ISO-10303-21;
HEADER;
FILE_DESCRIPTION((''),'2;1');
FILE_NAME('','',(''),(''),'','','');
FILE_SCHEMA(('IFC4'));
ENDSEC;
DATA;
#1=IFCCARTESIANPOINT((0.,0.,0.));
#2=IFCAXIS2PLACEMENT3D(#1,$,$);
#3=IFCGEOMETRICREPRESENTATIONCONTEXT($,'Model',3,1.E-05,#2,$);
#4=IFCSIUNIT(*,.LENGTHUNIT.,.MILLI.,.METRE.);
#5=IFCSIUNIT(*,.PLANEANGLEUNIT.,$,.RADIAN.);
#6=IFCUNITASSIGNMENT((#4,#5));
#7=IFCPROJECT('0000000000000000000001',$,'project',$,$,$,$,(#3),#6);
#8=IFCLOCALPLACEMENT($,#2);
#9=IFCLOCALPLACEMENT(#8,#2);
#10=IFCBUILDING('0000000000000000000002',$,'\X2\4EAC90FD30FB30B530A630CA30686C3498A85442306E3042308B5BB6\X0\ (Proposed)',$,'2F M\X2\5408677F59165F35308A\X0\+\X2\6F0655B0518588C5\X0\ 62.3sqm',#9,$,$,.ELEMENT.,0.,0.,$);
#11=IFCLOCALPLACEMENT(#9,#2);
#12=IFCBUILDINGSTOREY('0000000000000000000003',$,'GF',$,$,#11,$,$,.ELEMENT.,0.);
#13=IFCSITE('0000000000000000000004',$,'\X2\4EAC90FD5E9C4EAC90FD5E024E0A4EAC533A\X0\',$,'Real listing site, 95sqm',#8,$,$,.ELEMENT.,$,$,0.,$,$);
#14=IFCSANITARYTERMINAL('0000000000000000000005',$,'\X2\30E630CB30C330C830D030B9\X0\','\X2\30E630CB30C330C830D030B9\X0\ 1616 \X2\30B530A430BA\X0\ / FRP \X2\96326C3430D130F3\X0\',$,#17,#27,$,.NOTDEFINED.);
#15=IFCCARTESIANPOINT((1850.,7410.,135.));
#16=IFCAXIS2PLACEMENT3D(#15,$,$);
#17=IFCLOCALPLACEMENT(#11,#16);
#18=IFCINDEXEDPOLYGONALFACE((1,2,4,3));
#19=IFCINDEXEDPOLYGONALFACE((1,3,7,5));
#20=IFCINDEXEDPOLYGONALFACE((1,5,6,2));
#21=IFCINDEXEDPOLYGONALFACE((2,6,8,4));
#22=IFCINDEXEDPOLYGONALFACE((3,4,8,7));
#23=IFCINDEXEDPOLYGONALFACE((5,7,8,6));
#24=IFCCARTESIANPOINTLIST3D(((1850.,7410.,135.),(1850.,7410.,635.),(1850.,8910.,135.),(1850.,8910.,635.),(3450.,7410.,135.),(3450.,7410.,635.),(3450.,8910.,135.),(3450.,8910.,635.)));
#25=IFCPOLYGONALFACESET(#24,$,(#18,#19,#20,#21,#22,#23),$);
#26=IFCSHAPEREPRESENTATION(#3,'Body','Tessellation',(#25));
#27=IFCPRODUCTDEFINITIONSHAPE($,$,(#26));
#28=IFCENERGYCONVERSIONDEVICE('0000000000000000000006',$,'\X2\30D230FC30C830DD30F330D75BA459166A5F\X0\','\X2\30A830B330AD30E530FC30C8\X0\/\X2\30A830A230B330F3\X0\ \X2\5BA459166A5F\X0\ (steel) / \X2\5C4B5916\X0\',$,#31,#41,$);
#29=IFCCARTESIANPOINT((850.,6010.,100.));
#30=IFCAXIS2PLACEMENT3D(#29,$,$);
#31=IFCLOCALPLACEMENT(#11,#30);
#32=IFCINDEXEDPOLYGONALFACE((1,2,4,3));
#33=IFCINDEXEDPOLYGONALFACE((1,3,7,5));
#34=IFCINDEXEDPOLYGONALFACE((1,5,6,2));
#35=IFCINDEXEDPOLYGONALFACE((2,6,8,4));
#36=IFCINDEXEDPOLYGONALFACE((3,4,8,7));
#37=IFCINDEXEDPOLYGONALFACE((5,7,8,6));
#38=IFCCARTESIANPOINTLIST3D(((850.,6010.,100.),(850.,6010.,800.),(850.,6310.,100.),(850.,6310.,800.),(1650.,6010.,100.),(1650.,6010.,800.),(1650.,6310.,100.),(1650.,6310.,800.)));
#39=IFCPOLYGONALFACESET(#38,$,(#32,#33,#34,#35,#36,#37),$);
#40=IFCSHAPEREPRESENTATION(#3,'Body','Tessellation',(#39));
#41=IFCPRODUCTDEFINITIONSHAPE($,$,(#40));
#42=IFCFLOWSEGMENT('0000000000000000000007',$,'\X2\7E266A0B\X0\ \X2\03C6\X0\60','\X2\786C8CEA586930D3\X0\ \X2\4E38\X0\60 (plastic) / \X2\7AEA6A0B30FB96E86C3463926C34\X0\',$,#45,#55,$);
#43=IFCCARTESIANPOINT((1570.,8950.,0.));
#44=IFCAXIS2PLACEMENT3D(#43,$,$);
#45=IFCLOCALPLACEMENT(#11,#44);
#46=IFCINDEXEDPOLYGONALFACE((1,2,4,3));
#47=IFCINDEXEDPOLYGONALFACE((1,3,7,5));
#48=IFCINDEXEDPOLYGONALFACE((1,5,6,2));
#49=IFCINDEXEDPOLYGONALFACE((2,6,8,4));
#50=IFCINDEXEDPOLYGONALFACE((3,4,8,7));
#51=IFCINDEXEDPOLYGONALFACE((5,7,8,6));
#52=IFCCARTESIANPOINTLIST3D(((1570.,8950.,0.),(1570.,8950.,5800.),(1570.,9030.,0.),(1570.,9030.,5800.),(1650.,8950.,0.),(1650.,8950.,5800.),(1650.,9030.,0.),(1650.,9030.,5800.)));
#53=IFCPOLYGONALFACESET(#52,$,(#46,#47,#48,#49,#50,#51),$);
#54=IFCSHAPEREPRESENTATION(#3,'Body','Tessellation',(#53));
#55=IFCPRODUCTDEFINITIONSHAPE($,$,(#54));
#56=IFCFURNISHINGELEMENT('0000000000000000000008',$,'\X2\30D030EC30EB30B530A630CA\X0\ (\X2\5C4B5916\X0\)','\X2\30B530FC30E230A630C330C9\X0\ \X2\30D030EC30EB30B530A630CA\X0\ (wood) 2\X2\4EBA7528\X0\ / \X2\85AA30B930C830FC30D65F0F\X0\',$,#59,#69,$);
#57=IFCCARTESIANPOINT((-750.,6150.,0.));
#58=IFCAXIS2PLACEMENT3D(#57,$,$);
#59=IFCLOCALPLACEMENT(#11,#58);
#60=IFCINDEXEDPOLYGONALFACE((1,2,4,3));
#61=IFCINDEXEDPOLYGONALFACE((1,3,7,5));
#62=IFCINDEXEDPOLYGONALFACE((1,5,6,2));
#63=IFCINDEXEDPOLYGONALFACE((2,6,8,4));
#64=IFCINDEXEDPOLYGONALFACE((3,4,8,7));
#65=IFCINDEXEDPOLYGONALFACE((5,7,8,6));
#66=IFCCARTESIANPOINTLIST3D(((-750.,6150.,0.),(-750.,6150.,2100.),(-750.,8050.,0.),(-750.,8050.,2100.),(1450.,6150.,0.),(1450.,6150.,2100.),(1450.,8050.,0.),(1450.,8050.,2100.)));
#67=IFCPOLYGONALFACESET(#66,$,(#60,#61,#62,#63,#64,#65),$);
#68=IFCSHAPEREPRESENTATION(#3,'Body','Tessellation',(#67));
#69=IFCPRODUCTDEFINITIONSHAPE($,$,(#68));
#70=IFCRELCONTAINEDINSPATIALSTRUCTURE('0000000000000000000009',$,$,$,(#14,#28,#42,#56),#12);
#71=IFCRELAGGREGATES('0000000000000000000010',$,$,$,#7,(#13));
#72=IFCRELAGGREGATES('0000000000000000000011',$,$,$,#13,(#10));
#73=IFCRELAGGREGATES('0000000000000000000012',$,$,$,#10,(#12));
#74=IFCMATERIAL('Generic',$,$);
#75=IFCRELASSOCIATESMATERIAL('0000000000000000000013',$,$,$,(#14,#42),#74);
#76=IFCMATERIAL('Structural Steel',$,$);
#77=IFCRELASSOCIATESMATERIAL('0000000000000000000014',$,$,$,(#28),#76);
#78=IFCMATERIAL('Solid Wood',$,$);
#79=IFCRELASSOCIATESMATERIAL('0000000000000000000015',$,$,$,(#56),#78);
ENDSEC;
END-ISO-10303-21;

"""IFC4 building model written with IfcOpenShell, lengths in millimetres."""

from ifc_helpers import new_model, si_unit, frame, frame_2d, origin, place, context, project, spatial, rectangle, extrude, material, element, save


model = new_model("IFC4")

# Units and contexts
model_context = context("Model", 3, precision=1e-05, world=origin())
ifc_project = project(units=[si_unit("LENGTHUNIT", "METRE", prefix="MILLI"), si_unit("PLANEANGLEUNIT", "RADIAN")], contexts=[model_context])

# Site, building, storey
site_placement = place(None, origin())
site = spatial("IfcSite", under=ifc_project, at=site_placement, Name="京都府京都市上京区", ObjectType="Real listing site, 95sqm", CompositionType="ELEMENT", RefElevation=0.0)
building_placement = place(site_placement, origin())
building = spatial("IfcBuilding", under=site, at=building_placement, Name="京都・サウナと水風呂のある家 (Proposed)", ObjectType="2F M合板外張り+漆喰内装 62.3sqm", CompositionType="ELEMENT", ElevationOfRefHeight=0.0, ElevationOfTerrain=0.0)
storey_placement = place(building_placement, origin())
storey = spatial("IfcBuildingStorey", under=building, at=storey_placement, Name="GF", CompositionType="ELEMENT", Elevation=0.0)

# Shared definitions
ifc_material_1 = material(Name="Solid Wood")

# Shared definitions
ifc_material_2 = material(Name="Generic")

# Sanitary terminal
sanitary_terminal_placement = place(storey_placement, frame((1850.0, 7410.0, 135.0)))
element("IfcSanitaryTerminal", 1, at=sanitary_terminal_placement, inside=storey, material=ifc_material_2, Name="ユニットバス", Description="ユニットバス 1616 サイズ / FRP 防水パン", PredefinedType="NOTDEFINED", context=model_context, shape_type="SweptSolid", body=[
    extrude(rectangle(XDim=1600.0, YDim=1500.0, at=frame_2d((800.0, 750.0))), frame((1850.0, 7410.0, 135.0)), (0.0, 0.0, 1.0), 500.0),
])

# Energy conversion device
ifc_material_3 = material(Name="Structural Steel")
energy_conversion_device_placement = place(storey_placement, frame((850.0, 6010.0, 100.0)))
element("IfcEnergyConversionDevice", 2, at=energy_conversion_device_placement, inside=storey, material=ifc_material_3, Name="ヒートポンプ室外機", Description="エコキュート/エアコン 室外機 (steel) / 屋外", context=model_context, shape_type="SweptSolid", body=[
    extrude(rectangle(XDim=800.0, YDim=300.0, at=frame_2d((400.0, 150.0))), frame((850.0, 6010.0, 100.0)), (0.0, 0.0, 1.0), 700.0),
])

# Flow segment
flow_segment_placement = place(storey_placement, frame((1570.0, 8950.0, 0.0)))
element("IfcFlowSegment", 3, at=flow_segment_placement, inside=storey, material=ifc_material_2, Name="縦樋 φ60", Description="硬質塩ビ 丸60 (plastic) / 竪樋・雨水排水", context=model_context, shape_type="SweptSolid", body=[
    extrude(rectangle(XDim=80.0, YDim=80.0, at=frame_2d((40.0, 40.0))), frame((1570.0, 8950.0, 0.0)), (0.0, 0.0, 1.0), 5800.0),
])

# Furnishing element
furnishing_placement = place(storey_placement, frame((-750.0, 6150.0, 0.0)))
element("IfcFurnishingElement", 4, at=furnishing_placement, inside=storey, material=ifc_material_1, Name="バレルサウナ (屋外)", Description="サーモウッド バレルサウナ (wood) 2人用 / 薪ストーブ式", context=model_context, shape_type="SweptSolid", body=[
    extrude(rectangle(XDim=2200.0, YDim=1900.0, at=frame_2d((1100.0, 950.0))), frame((-750.0, 6150.0, 0.0)), (0.0, 0.0, 1.0), 2100.0),
])

save(model, "model.ifc")
